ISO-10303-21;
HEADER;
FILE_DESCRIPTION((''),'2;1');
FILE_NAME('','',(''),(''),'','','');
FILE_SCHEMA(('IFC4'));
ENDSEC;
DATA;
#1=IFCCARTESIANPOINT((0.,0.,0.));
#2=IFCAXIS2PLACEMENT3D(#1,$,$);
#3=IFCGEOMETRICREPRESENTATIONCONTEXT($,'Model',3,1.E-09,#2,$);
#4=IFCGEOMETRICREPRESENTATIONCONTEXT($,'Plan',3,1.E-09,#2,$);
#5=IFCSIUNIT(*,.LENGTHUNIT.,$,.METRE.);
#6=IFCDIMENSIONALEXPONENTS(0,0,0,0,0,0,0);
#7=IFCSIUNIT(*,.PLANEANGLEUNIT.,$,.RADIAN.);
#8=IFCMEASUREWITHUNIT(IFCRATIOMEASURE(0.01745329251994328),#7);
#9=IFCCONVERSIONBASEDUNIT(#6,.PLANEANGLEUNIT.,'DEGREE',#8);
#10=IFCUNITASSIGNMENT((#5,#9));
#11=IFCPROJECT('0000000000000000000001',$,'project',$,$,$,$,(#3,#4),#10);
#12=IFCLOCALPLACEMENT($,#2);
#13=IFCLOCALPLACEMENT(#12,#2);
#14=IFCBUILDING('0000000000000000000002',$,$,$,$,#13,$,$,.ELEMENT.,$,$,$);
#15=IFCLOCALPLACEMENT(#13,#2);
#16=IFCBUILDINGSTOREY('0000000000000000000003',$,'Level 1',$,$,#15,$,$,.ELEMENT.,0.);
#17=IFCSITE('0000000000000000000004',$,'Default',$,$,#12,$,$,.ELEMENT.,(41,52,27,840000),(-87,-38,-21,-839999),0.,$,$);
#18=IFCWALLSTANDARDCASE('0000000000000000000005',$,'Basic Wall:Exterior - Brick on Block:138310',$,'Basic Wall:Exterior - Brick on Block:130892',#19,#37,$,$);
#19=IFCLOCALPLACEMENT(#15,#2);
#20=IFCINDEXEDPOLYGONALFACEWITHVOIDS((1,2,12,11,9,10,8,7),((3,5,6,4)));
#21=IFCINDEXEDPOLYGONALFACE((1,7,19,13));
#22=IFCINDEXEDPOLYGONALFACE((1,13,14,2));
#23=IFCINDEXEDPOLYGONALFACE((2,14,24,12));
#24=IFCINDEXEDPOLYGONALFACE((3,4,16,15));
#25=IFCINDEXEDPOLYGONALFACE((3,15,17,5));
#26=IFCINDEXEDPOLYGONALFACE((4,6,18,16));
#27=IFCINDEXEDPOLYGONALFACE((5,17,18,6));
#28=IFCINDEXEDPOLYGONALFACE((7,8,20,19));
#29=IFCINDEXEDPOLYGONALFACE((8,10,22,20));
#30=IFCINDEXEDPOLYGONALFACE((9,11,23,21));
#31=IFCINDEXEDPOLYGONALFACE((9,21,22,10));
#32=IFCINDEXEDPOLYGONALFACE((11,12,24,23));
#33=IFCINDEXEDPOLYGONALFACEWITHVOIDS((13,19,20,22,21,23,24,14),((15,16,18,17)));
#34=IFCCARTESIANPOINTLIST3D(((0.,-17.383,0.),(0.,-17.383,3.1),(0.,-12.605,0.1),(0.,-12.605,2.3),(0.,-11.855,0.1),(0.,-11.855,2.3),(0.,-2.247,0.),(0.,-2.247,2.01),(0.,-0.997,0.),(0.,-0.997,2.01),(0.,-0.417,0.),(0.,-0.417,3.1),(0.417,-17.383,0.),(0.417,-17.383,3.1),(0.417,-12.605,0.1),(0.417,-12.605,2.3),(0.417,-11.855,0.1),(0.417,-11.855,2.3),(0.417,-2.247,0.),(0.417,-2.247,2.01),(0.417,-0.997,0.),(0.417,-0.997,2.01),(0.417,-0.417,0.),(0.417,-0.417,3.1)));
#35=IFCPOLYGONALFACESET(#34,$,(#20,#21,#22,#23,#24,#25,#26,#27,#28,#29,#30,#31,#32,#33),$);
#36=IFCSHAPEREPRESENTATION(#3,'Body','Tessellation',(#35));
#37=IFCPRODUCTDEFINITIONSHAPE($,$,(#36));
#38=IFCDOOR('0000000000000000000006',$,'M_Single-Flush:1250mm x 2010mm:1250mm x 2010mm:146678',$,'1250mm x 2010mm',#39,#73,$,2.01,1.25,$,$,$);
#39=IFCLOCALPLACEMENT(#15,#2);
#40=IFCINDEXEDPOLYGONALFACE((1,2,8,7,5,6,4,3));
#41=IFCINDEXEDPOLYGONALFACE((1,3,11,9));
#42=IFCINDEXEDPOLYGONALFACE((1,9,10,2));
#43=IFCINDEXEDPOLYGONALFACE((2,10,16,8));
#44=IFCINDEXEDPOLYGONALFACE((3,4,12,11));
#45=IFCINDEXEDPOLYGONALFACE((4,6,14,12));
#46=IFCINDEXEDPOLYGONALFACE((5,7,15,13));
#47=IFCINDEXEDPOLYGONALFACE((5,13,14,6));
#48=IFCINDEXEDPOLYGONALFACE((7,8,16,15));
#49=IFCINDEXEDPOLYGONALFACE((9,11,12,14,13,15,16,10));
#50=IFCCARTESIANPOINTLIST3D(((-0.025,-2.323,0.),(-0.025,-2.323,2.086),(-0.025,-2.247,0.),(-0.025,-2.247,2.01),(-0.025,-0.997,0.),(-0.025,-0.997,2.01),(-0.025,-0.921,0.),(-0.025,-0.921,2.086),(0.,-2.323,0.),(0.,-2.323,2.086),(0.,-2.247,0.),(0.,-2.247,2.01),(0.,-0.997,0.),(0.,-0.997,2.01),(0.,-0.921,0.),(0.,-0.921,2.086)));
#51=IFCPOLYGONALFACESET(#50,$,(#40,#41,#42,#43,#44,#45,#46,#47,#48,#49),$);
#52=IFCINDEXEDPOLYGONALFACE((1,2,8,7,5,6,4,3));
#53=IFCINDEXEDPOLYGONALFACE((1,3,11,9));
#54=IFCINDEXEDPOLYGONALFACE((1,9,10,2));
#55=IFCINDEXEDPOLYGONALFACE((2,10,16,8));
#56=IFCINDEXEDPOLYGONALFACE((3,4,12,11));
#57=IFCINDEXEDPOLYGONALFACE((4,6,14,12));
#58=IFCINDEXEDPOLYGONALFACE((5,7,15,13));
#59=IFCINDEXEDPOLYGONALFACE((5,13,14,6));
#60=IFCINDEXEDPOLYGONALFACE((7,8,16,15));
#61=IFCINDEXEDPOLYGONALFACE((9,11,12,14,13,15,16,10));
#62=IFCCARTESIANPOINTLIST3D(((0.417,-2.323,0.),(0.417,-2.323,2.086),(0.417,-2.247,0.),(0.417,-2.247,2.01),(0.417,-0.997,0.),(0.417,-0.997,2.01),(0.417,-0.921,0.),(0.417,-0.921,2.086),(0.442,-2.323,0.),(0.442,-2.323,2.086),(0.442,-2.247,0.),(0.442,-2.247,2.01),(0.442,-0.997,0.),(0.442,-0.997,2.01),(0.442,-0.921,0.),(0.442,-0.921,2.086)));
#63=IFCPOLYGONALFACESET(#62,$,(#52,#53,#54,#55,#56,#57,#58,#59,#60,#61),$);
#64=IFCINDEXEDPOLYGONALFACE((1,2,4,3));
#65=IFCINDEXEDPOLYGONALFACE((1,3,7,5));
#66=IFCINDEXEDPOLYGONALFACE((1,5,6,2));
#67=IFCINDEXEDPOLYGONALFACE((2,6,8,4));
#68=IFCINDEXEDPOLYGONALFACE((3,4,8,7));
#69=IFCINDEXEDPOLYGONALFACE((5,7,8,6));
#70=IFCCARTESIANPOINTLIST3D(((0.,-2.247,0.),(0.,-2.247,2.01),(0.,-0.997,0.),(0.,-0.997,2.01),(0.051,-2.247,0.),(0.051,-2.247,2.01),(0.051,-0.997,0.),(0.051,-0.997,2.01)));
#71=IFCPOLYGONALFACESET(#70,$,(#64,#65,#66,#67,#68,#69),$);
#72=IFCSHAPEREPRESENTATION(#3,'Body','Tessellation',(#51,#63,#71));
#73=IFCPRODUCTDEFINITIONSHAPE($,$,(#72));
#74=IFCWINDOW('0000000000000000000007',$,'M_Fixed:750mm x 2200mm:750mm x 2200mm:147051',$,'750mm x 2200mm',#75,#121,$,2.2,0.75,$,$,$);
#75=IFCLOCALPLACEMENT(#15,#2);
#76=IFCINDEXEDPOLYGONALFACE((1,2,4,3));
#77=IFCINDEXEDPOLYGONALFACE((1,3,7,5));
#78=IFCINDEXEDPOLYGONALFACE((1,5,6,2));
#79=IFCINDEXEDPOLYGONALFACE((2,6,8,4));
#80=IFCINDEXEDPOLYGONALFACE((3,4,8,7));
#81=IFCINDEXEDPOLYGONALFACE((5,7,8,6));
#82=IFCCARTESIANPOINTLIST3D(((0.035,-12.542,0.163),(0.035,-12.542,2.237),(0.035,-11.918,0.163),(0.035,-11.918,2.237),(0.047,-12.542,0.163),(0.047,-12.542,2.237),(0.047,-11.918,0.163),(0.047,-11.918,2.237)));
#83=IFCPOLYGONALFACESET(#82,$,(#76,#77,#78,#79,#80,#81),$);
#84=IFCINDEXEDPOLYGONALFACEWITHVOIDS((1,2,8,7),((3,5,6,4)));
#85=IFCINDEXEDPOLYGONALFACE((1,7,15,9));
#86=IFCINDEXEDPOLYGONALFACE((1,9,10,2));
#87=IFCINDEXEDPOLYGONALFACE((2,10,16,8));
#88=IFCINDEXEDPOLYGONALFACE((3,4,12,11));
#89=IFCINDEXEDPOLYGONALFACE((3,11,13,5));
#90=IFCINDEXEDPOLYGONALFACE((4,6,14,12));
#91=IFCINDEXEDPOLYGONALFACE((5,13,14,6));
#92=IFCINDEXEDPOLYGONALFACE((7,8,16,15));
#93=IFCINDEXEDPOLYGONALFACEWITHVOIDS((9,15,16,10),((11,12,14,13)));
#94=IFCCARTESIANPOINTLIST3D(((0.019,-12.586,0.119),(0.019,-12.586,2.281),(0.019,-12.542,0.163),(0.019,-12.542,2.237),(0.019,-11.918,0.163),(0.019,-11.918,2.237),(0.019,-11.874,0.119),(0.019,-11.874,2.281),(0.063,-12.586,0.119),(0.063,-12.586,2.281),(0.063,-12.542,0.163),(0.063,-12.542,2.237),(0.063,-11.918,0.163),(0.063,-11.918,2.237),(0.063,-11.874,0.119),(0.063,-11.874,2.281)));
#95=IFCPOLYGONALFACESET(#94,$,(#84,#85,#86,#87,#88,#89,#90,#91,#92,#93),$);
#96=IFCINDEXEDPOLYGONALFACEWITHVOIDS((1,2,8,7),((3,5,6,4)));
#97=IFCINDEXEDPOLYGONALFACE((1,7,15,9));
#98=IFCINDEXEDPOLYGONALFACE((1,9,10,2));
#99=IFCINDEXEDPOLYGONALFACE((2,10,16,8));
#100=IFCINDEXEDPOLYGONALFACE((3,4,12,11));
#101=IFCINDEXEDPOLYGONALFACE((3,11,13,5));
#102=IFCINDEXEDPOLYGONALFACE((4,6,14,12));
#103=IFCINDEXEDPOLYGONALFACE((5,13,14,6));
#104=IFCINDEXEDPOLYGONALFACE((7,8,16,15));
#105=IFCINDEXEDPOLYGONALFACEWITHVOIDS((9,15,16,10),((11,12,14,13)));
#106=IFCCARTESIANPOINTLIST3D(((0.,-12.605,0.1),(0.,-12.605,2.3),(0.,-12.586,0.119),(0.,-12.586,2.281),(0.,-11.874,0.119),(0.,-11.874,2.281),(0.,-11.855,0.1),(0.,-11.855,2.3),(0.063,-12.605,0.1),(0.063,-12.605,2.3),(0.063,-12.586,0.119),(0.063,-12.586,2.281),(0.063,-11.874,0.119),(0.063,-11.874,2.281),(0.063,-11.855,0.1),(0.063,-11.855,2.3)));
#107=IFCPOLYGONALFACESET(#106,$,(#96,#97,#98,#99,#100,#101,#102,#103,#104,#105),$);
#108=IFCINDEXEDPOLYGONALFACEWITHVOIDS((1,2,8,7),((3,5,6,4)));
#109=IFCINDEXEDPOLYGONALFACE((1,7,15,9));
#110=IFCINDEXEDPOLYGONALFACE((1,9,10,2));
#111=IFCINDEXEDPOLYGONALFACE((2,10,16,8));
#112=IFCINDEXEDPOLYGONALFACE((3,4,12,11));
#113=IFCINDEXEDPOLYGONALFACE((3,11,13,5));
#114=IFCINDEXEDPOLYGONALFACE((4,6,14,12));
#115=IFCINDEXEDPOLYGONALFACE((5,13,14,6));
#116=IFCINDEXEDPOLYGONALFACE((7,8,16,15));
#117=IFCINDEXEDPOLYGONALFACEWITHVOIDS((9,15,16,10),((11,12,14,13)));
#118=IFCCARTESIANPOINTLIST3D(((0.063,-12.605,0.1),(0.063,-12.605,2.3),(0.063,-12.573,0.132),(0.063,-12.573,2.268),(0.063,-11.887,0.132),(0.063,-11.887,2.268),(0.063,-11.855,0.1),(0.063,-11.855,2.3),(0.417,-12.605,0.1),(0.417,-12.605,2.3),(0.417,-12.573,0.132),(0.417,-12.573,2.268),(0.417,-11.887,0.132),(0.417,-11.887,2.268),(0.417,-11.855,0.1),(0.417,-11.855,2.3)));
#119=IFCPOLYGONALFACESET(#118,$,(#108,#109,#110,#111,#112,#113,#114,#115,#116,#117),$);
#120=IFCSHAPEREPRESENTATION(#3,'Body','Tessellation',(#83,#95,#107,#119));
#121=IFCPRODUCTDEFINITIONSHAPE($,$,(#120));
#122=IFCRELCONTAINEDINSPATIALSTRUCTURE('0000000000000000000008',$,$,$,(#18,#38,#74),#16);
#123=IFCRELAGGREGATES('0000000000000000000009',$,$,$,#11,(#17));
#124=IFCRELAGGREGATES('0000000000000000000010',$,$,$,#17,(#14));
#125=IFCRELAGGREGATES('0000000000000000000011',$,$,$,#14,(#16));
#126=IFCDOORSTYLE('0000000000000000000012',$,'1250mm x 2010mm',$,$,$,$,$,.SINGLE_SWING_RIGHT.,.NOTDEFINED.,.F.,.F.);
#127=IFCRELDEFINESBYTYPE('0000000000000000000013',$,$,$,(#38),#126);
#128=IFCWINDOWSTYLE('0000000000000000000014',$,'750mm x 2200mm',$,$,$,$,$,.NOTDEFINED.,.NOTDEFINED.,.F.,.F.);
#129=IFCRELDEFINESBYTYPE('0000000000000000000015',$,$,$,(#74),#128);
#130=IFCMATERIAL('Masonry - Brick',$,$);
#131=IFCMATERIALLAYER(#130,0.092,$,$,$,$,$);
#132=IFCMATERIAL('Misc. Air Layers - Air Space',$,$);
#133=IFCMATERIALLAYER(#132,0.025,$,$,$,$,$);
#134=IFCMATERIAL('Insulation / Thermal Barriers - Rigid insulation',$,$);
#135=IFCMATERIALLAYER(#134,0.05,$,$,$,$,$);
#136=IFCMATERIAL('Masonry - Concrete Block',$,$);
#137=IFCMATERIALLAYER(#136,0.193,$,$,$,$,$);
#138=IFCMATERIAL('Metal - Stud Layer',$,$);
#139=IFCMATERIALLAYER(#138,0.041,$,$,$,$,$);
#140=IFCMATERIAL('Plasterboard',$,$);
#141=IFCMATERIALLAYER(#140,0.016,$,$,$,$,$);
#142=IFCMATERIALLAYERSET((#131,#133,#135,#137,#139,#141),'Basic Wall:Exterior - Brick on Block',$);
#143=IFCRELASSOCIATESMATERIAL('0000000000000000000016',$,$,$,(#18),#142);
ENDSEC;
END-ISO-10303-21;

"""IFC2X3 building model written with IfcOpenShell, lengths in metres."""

from ifc_helpers import new_model, entity, si_unit, converted_unit, frame, frame_2d, origin, origin_2d_with_axis, place, context, project, spatial, polyline, rectangle, outline, extrude, source, transform, mapped, material, layer, layer_set, layer_usage, type_object, type_shapes, element, fill, save


model = new_model("IFC2X3")

# Units and contexts
model_context = context("Model", 3, precision=1e-09, world=origin())
plan_context = context("Plan", 3, precision=1e-09, world=origin())
ifc_project = project(units=[si_unit("LENGTHUNIT", "METRE"), converted_unit("PLANEANGLEUNIT", "DEGREE", entity("IfcRatioMeasure", 0.01745329251994328), si_unit("PLANEANGLEUNIT", "RADIAN"), dimensions=[0, 0, 0, 0, 0, 0, 0])], contexts=[model_context, plan_context])

# Site, building, storey
site_placement = place(None, origin())
site = spatial("IfcSite", under=ifc_project, at=site_placement, Name="Default", CompositionType="ELEMENT", RefLatitude=(41, 52, 27, 840000), RefLongitude=(-87, -38, -21, -839999), RefElevation=0.0)
building_placement = place(site_placement, origin())
building = spatial("IfcBuilding", under=site, at=building_placement, CompositionType="ELEMENT")
storey_placement = place(building_placement, origin())
storey = spatial("IfcBuildingStorey", under=building, at=storey_placement, Name="Level 1", CompositionType="ELEMENT", Elevation=0.0)

# Shared definitions
ifc_material_1 = material(Name="Masonry - Brick")
ifc_layer_1 = layer(ifc_material_1, 0.092)
ifc_material_2 = material(Name="Misc. Air Layers - Air Space")
ifc_layer_2 = layer(ifc_material_2, 0.025)
ifc_material_3 = material(Name="Insulation / Thermal Barriers - Rigid insulation")
ifc_layer_3 = layer(ifc_material_3, 0.05)
ifc_material_4 = material(Name="Masonry - Concrete Block")
ifc_layer_4 = layer(ifc_material_4, 0.193)
ifc_material_5 = material(Name="Metal - Stud Layer")
ifc_layer_5 = layer(ifc_material_5, 0.041)
ifc_material_6 = material(Name="Plasterboard")
ifc_layer_6 = layer(ifc_material_6, 0.016)
ifc_layer_set_1 = layer_set([ifc_layer_1, ifc_layer_2, ifc_layer_3, ifc_layer_4, ifc_layer_5, ifc_layer_6], Name="Basic Wall:Exterior - Brick on Block")

# Wall, openings, door, window
ifc_layer_usage_1 = layer_usage(ifc_layer_set_1, "AXIS2", "NEGATIVE", 0.2085)
wall_1_placement = place(storey_placement, frame((0.2085, -17.383, 0.0), z_axis=(0.0, 0.0, 1.0), x_axis=(0.0, 1.0, 0.0)))
wall_1 = element("IfcWallStandardCase", 1, at=wall_1_placement, inside=storey, material=ifc_layer_usage_1, Name="Basic Wall:Exterior - Brick on Block:138310", ObjectType="Basic Wall:Exterior - Brick on Block:130892", context=model_context, shape_type="SweptSolid", body=[
    extrude(rectangle(XDim=16.966, YDim=0.417, at=frame_2d((8.483, 0.0), x_axis=(-1.0, 0.0))), origin(), (0.0, 0.0, 1.0), 3.1),
])
opening_1_placement = place(wall_1_placement, frame((15.136, -0.2085, 0.0)))
opening_1 = element("IfcOpeningElement", 2, at=opening_1_placement, cuts=wall_1, ObjectType="Opening", context=model_context, shape_type="SweptSolid", body=[
    extrude(rectangle(XDim=1.25, YDim=2.01, at=frame_2d((1.005, 0.625), x_axis=(0.0, 1.0))), frame((0.0, 0.0, 0.0), z_axis=(0.0, 1.0, 0.0), x_axis=(0.0, 0.0, 1.0)), (0.0, 0.0, 1.0), 0.417),
])
opening_2_placement = place(wall_1_placement, frame((4.778, -0.2085, 0.1)))
opening_2 = element("IfcOpeningElement", 3, at=opening_2_placement, cuts=wall_1, ObjectType="Opening", context=model_context, shape_type="SweptSolid", body=[
    extrude(rectangle(XDim=2.2, YDim=0.75, at=frame_2d((1.1, 0.375), x_axis=(1.0, 0.0))), frame((0.0, 0.0, 0.0), z_axis=(0.0, 1.0, 0.0), x_axis=(0.0, 0.0, 1.0)), (0.0, 0.0, 1.0), 0.417),
])
door_style_1 = type_object("IfcDoorStyle", Name="1250mm x 2010mm", ConstructionType="NOTDEFINED", OperationType="SINGLE_SWING_RIGHT", ParameterTakesPrecedence=False, Sizeable=False)
shared_shape_1 = source(origin(), model_context, "Body", "SweptSolid", [
    extrude(outline(polyline([(-0.701, -1.062), (0.701, -1.062), (0.701, 1.024), (0.625, 1.024), (0.625, -0.986), (-0.625, -0.986), (-0.625, 1.024), (-0.701, 1.024), (-0.701, -1.062)])), frame((0.625, 0.417, 1.024), z_axis=(0.0, 1.0, 0.0), x_axis=(1.0, 0.0, 0.0)), (0.0, 0.0, 1.0), 0.025),
    extrude(outline(polyline([(-1.062, -0.701), (1.024, -0.701), (1.024, -0.625), (-0.986, -0.625), (-0.986, 0.625), (1.024, 0.625), (1.024, 0.701), (-1.062, 0.701), (-1.062, -0.701)])), frame((0.625, -0.025, 1.024), z_axis=(0.0, 1.0, 0.0), x_axis=(0.0, 0.0, -1.0)), (0.0, 0.0, 1.0), 0.025),
    extrude(rectangle(XDim=0.051, YDim=1.25, at=origin_2d_with_axis()), frame((0.625, 0.3915, 0.0), z_axis=(0.0, 0.0, 1.0), x_axis=(0.0, 1.0, 0.0)), (0.0, 0.0, 1.0), 2.01),
])
type_shapes(door_style_1, [shared_shape_1])
door_1_placement = place(opening_1_placement, origin())
door_1 = element("IfcDoor", 4, at=door_1_placement, inside=storey, type_object=door_style_1, Name="M_Single-Flush:1250mm x 2010mm:1250mm x 2010mm:146678", ObjectType="1250mm x 2010mm", OverallHeight=2.01, OverallWidth=1.25, context=model_context, shape_type="MappedRepresentation", body=[
    mapped(shared_shape_1, transform((0.0, 0.0, 0.0), scale=1.0)),
])
fill(opening_1, door_1)
window_style_1 = type_object("IfcWindowStyle", Name="750mm x 2200mm", ConstructionType="NOTDEFINED", OperationType="NOTDEFINED", ParameterTakesPrecedence=False, Sizeable=False)
shared_shape_2 = source(origin(), model_context, "Body", "SweptSolid", [
    extrude(rectangle(XDim=0.012, YDim=0.624, at=origin_2d_with_axis()), frame((0.375, 0.376, 0.063), z_axis=(0.0, 0.0, 1.0), x_axis=(0.0, -1.0, 0.0)), (0.0, 0.0, 1.0), 2.074),
    extrude(outline(polyline([(-0.356, -1.081), (0.356, -1.081), (0.356, 1.081), (-0.356, 1.081), (-0.356, -1.081)]), holes=[polyline([(-0.312, -1.037), (-0.312, 1.037), (0.312, 1.037), (0.312, -1.037), (-0.312, -1.037)])]), frame((0.375, 0.354, 1.1), z_axis=(0.0, 1.0, 0.0), x_axis=(1.0, 0.0, 0.0)), (0.0, 0.0, 1.0), 0.044),
    extrude(outline(polyline([(-0.375, -1.1), (0.375, -1.1), (0.375, 1.1), (-0.375, 1.1), (-0.375, -1.1)]), holes=[polyline([(-0.356, -1.081), (-0.356, 1.081), (0.356, 1.081), (0.356, -1.081), (-0.356, -1.081)])]), frame((0.375, 0.354, 1.1), z_axis=(0.0, 1.0, 0.0), x_axis=(1.0, 0.0, 0.0)), (0.0, 0.0, 1.0), 0.063),
    extrude(outline(polyline([(-0.375, -1.1), (0.375, -1.1), (0.375, 1.1), (-0.375, 1.1), (-0.375, -1.1)]), holes=[polyline([(-0.343, -1.068), (-0.343, 1.068), (0.343, 1.068), (0.343, -1.068), (-0.343, -1.068)])]), frame((0.375, 0.0, 1.1), z_axis=(0.0, 1.0, 0.0), x_axis=(1.0, 0.0, 0.0)), (0.0, 0.0, 1.0), 0.354),
])
type_shapes(window_style_1, [shared_shape_2])
window_1_placement = place(opening_2_placement, origin())
window_1 = element("IfcWindow", 5, at=window_1_placement, inside=storey, type_object=window_style_1, Name="M_Fixed:750mm x 2200mm:750mm x 2200mm:147051", ObjectType="750mm x 2200mm", OverallHeight=2.2, OverallWidth=0.75, context=model_context, shape_type="MappedRepresentation", body=[
    mapped(shared_shape_2, transform((0.0, 0.0, 0.0), scale=1.0)),
])
fill(opening_2, window_1)

save(model, "model.ifc")
